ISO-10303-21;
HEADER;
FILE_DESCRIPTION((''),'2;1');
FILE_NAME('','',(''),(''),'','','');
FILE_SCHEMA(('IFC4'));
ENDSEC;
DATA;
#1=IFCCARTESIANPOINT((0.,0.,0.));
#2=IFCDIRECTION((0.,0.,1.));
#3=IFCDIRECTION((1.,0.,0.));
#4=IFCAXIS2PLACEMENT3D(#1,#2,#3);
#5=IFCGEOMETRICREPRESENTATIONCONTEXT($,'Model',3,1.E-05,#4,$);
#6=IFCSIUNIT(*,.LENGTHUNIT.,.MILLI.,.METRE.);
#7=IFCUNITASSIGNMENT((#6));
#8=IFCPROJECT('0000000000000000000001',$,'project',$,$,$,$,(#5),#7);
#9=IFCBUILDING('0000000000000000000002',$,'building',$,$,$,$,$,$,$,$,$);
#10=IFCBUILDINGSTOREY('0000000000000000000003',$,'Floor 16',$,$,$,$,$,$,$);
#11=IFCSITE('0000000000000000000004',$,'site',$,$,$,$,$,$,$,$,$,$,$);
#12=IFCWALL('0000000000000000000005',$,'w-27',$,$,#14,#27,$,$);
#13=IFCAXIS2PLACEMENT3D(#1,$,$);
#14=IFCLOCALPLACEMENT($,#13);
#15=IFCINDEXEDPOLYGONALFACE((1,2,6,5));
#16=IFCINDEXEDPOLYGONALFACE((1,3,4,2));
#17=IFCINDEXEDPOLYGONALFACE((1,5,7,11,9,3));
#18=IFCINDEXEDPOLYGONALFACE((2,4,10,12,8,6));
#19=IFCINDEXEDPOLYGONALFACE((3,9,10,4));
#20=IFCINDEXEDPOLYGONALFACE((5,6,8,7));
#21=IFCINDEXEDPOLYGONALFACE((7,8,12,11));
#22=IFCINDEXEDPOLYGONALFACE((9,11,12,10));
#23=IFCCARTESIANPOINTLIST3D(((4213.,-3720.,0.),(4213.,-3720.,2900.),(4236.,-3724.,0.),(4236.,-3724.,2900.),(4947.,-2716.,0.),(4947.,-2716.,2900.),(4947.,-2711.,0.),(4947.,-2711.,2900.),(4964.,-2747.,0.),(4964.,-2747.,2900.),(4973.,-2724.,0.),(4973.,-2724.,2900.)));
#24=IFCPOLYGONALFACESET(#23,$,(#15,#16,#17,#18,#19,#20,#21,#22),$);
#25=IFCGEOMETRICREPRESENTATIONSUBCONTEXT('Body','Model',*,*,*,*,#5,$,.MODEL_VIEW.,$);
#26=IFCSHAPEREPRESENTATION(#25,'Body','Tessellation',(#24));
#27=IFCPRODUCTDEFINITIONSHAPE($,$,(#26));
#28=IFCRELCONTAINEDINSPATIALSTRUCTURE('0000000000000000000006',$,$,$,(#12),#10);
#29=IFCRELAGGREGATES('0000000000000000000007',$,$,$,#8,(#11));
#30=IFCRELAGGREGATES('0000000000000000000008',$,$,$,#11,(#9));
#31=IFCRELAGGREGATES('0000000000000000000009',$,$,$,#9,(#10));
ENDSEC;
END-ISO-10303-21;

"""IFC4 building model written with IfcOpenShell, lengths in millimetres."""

from ifc_helpers import new_model, si_unit, origin_with_axes, place, context, subcontext, project, spatial, indexed_curve, outline, extrude, element, save


model = new_model("IFC4")

# Units and contexts
model_context = context("Model", 3, precision=1e-05, world=origin_with_axes())
body_context = subcontext(model_context, "Body", "Model", "MODEL_VIEW")
ifc_project = project(units=[si_unit("LENGTHUNIT", "METRE", prefix="MILLI")], contexts=[model_context])

# Site, building, storey
site = spatial("IfcSite", under=ifc_project, Name="site")
building = spatial("IfcBuilding", under=site, Name="building")
storey = spatial("IfcBuildingStorey", under=building, Name="Floor 16")

# Wall
wall_1_placement = place(None, origin_with_axes())
element("IfcWall", 1, at=wall_1_placement, inside=storey, Name="w-27", context=body_context, shape_type="SweptSolid", body=[
    extrude(outline(indexed_curve([(4947.0, -2711.0), (4947.0, -2716.0), (4213.0, -3720.0), (4236.0, -3724.0), (4964.0, -2747.0), (4973.0, -2724.0)])), None, (0.0, 0.0, 1.0), 2900.0),
])

save(model, "model.ifc")
